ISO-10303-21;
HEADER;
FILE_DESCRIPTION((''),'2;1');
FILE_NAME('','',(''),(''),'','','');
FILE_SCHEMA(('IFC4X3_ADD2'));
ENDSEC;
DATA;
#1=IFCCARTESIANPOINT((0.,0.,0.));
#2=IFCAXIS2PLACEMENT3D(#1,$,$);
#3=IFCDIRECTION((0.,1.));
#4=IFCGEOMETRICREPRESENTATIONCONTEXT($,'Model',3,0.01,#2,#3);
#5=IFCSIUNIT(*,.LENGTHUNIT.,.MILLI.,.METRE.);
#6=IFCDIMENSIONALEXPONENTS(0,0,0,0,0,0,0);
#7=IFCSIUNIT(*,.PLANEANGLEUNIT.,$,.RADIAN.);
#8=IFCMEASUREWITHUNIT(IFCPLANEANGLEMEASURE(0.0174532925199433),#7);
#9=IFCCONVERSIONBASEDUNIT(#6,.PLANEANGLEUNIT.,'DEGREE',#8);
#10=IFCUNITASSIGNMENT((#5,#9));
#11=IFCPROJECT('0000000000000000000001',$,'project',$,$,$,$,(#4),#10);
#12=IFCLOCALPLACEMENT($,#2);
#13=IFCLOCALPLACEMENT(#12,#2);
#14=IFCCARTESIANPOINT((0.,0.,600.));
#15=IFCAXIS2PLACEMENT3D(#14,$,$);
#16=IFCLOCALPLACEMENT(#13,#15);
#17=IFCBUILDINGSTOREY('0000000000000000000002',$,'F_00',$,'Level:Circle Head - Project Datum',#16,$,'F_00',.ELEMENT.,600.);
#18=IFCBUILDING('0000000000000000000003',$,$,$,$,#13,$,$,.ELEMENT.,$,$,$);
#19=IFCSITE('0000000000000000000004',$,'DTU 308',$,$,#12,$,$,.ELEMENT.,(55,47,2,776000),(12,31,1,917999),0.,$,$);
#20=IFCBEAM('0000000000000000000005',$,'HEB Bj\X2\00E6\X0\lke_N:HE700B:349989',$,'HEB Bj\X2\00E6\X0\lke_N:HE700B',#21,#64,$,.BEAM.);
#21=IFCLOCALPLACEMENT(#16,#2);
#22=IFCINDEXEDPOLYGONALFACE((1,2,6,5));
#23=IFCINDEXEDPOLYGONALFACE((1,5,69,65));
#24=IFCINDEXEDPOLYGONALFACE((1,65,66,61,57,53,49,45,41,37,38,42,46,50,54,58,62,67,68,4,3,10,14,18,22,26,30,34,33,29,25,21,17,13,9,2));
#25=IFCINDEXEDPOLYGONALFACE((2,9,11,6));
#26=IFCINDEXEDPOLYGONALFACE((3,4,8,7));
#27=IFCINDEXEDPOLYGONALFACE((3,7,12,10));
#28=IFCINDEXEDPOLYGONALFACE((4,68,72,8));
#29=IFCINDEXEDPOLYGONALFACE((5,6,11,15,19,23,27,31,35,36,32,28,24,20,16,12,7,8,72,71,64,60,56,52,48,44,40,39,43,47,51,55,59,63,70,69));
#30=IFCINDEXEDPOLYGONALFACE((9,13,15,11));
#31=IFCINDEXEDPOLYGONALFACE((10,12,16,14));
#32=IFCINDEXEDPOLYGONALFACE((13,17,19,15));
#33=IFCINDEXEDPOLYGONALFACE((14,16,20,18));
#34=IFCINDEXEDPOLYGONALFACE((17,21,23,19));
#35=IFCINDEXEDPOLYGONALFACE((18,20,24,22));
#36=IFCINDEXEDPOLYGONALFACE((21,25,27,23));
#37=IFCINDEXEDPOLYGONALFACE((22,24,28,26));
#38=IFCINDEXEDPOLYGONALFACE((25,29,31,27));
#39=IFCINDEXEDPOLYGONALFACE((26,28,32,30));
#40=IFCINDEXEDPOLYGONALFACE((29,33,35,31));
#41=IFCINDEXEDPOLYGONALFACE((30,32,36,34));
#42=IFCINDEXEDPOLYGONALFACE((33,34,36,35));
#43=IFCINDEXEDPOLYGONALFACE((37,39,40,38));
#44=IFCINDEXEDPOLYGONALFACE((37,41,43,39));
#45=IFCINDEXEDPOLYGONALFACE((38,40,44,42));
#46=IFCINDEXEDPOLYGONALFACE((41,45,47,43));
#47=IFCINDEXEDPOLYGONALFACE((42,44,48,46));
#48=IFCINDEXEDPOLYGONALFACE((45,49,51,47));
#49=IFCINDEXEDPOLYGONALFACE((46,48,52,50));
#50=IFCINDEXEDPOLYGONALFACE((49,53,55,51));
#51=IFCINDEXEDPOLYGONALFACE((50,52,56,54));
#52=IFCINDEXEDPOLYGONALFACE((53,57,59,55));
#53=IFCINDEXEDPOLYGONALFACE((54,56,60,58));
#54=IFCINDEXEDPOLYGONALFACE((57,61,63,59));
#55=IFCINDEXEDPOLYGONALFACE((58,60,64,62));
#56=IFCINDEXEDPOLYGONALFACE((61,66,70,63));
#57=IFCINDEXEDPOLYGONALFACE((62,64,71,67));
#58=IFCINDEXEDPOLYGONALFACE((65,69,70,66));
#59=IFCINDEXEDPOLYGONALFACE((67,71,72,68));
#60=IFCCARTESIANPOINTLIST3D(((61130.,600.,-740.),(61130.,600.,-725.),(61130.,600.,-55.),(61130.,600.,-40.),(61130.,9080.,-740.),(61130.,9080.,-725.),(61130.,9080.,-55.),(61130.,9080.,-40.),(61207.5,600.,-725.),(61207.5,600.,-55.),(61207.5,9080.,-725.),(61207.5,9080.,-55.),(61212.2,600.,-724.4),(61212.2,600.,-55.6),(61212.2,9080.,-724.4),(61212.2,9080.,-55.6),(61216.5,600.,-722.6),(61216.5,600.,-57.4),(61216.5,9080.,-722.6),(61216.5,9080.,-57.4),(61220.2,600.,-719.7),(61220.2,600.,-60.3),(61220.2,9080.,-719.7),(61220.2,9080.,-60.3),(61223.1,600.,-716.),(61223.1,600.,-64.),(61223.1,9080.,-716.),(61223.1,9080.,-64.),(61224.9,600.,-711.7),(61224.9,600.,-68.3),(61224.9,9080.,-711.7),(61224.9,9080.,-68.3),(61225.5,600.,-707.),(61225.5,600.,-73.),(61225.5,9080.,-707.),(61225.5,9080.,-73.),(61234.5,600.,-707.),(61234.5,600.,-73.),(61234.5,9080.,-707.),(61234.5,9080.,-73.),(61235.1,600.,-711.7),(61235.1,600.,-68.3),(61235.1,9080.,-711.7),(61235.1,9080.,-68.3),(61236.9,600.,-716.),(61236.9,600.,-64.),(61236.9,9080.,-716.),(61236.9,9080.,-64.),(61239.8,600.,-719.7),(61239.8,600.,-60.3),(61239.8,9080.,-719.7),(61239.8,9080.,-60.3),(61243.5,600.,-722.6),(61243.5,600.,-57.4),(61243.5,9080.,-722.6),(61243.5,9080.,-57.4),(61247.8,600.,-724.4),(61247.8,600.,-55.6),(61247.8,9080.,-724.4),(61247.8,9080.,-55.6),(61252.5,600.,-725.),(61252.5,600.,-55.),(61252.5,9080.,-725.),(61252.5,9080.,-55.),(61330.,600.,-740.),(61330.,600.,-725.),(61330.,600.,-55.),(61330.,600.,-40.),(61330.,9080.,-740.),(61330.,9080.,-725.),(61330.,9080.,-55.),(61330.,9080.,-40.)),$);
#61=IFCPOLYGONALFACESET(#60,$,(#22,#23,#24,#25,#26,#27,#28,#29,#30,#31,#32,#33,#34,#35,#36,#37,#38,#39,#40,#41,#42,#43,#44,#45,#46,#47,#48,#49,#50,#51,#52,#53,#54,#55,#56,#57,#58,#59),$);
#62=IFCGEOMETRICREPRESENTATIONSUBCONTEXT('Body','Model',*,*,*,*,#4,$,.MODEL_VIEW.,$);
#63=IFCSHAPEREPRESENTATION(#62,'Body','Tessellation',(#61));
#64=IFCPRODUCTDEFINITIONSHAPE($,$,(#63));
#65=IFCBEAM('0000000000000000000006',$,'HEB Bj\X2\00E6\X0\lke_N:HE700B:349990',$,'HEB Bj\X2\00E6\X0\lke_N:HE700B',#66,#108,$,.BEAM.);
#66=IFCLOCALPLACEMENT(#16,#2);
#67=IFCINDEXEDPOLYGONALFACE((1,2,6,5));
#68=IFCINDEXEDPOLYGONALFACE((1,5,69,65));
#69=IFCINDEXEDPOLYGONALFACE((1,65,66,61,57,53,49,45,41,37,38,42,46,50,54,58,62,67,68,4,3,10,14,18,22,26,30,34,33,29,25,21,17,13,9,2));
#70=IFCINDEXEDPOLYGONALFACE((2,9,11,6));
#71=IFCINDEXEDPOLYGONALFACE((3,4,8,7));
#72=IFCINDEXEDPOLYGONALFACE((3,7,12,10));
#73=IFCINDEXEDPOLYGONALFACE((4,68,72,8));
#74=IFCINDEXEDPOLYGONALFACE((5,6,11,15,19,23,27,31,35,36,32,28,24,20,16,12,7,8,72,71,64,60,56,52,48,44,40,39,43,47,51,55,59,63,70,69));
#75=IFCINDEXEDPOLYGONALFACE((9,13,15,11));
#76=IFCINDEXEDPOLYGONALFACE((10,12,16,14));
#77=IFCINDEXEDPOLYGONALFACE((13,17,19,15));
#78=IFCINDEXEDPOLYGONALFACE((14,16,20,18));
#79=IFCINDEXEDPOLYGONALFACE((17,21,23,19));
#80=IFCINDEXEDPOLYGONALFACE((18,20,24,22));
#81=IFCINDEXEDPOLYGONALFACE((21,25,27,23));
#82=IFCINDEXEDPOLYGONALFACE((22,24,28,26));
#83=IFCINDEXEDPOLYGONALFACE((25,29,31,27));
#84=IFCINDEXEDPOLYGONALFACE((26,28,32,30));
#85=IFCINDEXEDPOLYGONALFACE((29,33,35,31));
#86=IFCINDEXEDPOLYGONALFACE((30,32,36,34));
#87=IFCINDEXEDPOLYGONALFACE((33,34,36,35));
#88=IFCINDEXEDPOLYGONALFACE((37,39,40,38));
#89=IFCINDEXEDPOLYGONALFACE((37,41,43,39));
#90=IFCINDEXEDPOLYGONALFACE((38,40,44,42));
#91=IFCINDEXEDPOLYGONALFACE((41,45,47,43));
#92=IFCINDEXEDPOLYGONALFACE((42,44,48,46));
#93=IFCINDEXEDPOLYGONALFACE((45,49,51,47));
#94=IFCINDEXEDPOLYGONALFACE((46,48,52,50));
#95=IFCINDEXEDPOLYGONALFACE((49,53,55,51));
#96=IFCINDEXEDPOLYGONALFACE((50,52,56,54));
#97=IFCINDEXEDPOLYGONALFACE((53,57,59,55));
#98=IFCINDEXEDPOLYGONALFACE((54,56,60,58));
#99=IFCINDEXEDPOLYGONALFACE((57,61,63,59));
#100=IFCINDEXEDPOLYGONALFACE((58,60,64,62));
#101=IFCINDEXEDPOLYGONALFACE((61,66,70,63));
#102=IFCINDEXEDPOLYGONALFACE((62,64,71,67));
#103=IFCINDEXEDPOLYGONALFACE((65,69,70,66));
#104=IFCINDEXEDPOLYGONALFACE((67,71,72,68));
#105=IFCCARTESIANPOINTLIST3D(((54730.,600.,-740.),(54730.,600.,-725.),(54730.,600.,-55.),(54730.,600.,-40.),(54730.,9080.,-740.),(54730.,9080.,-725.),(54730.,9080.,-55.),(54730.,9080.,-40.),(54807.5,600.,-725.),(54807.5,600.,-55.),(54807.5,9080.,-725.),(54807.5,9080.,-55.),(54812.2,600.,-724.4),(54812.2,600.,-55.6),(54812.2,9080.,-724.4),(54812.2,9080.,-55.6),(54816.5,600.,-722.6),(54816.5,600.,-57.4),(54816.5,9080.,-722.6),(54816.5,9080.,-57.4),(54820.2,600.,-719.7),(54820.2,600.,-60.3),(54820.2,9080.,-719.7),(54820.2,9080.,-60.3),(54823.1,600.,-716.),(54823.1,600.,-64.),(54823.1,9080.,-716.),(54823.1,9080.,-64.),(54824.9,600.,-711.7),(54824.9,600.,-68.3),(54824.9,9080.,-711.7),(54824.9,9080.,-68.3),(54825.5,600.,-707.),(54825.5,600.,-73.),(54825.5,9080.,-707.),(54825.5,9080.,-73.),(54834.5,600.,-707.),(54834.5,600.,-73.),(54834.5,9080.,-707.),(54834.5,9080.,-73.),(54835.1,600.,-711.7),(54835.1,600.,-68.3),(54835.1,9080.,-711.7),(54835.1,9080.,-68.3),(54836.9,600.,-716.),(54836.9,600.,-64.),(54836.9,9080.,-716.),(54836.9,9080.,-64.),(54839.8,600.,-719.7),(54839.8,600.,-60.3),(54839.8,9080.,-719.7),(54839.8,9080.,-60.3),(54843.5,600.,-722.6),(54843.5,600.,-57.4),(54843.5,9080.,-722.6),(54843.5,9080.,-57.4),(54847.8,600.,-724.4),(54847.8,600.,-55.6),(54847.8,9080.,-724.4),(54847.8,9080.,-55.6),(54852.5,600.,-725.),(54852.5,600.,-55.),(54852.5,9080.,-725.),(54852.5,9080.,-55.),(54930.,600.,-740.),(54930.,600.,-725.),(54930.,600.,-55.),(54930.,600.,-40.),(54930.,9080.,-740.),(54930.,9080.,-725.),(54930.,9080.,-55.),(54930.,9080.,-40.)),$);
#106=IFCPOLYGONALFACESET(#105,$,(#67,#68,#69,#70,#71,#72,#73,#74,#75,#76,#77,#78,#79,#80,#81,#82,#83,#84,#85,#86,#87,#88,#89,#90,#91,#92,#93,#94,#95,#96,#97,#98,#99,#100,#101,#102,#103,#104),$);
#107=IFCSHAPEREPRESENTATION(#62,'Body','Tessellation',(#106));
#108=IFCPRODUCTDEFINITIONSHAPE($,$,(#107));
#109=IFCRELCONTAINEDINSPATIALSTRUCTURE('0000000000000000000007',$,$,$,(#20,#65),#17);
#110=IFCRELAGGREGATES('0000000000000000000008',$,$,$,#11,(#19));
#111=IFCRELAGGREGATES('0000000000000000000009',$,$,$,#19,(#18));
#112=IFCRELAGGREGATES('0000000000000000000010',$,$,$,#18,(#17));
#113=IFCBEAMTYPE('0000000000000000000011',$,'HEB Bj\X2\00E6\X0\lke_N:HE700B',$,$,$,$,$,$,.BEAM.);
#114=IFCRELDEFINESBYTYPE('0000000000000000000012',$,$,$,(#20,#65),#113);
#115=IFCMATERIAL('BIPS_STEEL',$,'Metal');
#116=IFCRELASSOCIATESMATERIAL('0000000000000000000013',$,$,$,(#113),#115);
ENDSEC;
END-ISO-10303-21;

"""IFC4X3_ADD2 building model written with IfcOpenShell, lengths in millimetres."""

from ifc_helpers import new_model, entity, si_unit, converted_unit, direction, frame, frame_2d, origin, place, context, subcontext, project, spatial, i_section, extrude, source, transform, mapped, material, material_profile, profile_set, type_object, element, save


model = new_model("IFC4X3_ADD2")

# Units and contexts
model_context = context("Model", 3, precision=0.01, world=origin(), true_north=direction((0.0, 1.0)))
body_context = subcontext(model_context, "Body", "Model", "MODEL_VIEW")
ifc_project = project(units=[si_unit("LENGTHUNIT", "METRE", prefix="MILLI"), converted_unit("PLANEANGLEUNIT", "DEGREE", entity("IfcPlaneAngleMeasure", 0.0174532925199433), si_unit("PLANEANGLEUNIT", "RADIAN"), dimensions=[0, 0, 0, 0, 0, 0, 0])], contexts=[model_context])

# Site, building, storey
site_placement = place(None, origin())
site = spatial("IfcSite", under=ifc_project, at=site_placement, Name="DTU 308", CompositionType="ELEMENT", RefLatitude=(55, 47, 2, 776000), RefLongitude=(12, 31, 1, 917999), RefElevation=0.0)
building_placement = place(site_placement, origin())
building = spatial("IfcBuilding", under=site, at=building_placement, CompositionType="ELEMENT")
storey_placement = place(building_placement, frame((0.0, 0.0, 600.0)))
storey = spatial("IfcBuildingStorey", under=building, at=storey_placement, Name="F_00", ObjectType="Level:Circle Head - Project Datum", LongName="F_00", CompositionType="ELEMENT", Elevation=600.0)

# Beams
ifc_material_1 = material(Name="BIPS_STEEL", Category="Metal")
ifc_material_profile_1 = material_profile(ifc_material_1, i_section(OverallWidth=200.0, OverallDepth=700.0, WebThickness=9.0, FlangeThickness=15.0, FilletRadius=18.0, at=frame_2d((0.0, 0.0), x_axis=(1.0, 0.0))), Name="HE700B")
ifc_profile_set_1 = profile_set([ifc_material_profile_1], Name="HE700B")
beam_type = type_object("IfcBeamType", Name="HEB Bjælke_N:HE700B", PredefinedType="BEAM", material=ifc_profile_set_1)
shared_shape_1 = source(origin(), body_context, "Body", "SweptSolid", [
    extrude(i_section(OverallWidth=200.0, OverallDepth=700.0, WebThickness=9.0, FlangeThickness=15.0, FilletRadius=18.0, at=frame_2d((0.0, 0.0), x_axis=(1.0, 0.0))), frame((61230.0, 9080.0, 210.0), z_axis=(0.0, -1.0, 0.0), x_axis=(-1.0, 0.0, 0.0)), (0.0, 0.0, 1.0), 8480.0),
])
beam_1_placement = place(storey_placement, frame((0.0, 0.0, -600.0)))
element("IfcBeam", 1, at=beam_1_placement, inside=storey, type_object=beam_type, Name="HEB Bjælke_N:HE700B:349989", ObjectType="HEB Bjælke_N:HE700B", PredefinedType="BEAM", context=body_context, shape_type="MappedRepresentation", body=[
    mapped(shared_shape_1, transform((0.0, 0.0, 0.0), scale=1.0)),
])
shared_shape_2 = source(origin(), body_context, "Body", "SweptSolid", [
    extrude(i_section(OverallWidth=200.0, OverallDepth=700.0, WebThickness=9.0, FlangeThickness=15.0, FilletRadius=18.0, at=frame_2d((0.0, 0.0), x_axis=(1.0, 0.0))), frame((54830.0, 9080.0, 210.0), z_axis=(0.0, -1.0, 0.0), x_axis=(-1.0, 0.0, 0.0)), (0.0, 0.0, 1.0), 8480.0),
])
beam_2_placement = place(storey_placement, frame((0.0, 0.0, -600.0)))
element("IfcBeam", 2, at=beam_2_placement, inside=storey, type_object=beam_type, Name="HEB Bjælke_N:HE700B:349990", ObjectType="HEB Bjælke_N:HE700B", PredefinedType="BEAM", context=body_context, shape_type="MappedRepresentation", body=[
    mapped(shared_shape_2, transform((0.0, 0.0, 0.0), scale=1.0)),
])

save(model, "model.ifc")
